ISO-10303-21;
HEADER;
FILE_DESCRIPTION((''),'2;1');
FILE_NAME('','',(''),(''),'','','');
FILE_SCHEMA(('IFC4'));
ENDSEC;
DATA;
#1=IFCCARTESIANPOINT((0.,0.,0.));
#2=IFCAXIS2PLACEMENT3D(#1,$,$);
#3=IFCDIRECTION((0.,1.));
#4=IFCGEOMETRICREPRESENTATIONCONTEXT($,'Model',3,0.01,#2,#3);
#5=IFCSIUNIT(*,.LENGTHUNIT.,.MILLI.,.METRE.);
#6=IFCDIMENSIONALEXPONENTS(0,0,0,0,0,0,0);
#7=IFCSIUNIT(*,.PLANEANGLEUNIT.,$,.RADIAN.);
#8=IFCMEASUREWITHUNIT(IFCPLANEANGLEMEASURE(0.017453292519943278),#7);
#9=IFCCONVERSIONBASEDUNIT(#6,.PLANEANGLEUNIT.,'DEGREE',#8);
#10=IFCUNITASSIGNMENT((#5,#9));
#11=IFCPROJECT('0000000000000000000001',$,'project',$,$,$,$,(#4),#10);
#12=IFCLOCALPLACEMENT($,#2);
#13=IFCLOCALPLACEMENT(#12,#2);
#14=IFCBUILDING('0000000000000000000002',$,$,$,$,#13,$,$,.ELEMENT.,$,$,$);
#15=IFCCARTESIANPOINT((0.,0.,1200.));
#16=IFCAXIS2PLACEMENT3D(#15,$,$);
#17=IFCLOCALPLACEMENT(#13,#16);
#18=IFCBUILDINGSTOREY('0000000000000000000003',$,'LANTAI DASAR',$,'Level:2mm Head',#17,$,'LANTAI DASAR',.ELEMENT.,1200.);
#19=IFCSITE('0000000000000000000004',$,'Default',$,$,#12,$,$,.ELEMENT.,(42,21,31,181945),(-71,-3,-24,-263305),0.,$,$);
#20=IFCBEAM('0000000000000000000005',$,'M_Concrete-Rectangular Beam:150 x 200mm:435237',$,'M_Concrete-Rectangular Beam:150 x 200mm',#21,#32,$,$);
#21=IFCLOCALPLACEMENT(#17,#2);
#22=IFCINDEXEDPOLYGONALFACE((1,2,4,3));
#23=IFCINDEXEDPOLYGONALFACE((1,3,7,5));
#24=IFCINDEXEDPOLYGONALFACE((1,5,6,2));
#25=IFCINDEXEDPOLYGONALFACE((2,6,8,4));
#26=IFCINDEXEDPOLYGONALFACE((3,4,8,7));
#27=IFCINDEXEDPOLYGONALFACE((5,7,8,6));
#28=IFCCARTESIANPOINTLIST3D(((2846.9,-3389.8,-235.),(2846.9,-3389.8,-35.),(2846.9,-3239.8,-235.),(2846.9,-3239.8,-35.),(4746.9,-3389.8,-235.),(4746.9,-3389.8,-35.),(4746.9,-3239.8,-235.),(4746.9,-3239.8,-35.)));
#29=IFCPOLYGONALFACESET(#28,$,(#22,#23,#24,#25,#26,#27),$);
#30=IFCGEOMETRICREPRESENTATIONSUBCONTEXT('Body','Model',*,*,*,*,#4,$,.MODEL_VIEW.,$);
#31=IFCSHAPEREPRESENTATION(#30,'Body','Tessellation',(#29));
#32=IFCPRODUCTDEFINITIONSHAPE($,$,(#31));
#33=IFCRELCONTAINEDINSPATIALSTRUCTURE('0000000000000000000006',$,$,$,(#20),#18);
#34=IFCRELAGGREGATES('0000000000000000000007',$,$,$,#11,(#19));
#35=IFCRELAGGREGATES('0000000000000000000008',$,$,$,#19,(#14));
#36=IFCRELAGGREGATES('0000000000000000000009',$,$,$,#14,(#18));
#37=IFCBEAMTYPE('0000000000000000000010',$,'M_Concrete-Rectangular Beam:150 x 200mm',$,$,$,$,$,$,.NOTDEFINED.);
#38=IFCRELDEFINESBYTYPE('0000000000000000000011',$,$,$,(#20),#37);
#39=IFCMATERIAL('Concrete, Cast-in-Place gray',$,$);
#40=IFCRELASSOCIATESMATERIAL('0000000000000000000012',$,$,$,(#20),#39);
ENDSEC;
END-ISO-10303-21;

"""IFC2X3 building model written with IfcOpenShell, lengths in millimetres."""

from ifc_helpers import new_model, entity, si_unit, converted_unit, direction, frame, frame_2d, origin, place, context, subcontext, project, spatial, rectangle, extrude, material, type_object, element, save


model = new_model("IFC2X3")

# Units and contexts
model_context = context("Model", 3, precision=0.01, world=origin(), true_north=direction((0.0, 1.0)))
body_context = subcontext(model_context, "Body", "Model", "MODEL_VIEW")
ifc_project = project(units=[si_unit("LENGTHUNIT", "METRE", prefix="MILLI"), converted_unit("PLANEANGLEUNIT", "DEGREE", entity("IfcPlaneAngleMeasure", 0.017453292519943278), si_unit("PLANEANGLEUNIT", "RADIAN"), dimensions=[0, 0, 0, 0, 0, 0, 0])], contexts=[model_context])

# Site, building, storey
site_placement = place(None, origin())
site = spatial("IfcSite", under=ifc_project, at=site_placement, Name="Default", CompositionType="ELEMENT", RefLatitude=(42, 21, 31, 181945), RefLongitude=(-71, -3, -24, -263305), RefElevation=0.0)
building_placement = place(site_placement, origin())
building = spatial("IfcBuilding", under=site, at=building_placement, CompositionType="ELEMENT")
storey_placement = place(building_placement, frame((0.0, 0.0, 1200.0)))
storey = spatial("IfcBuildingStorey", under=building, at=storey_placement, Name="LANTAI DASAR", ObjectType="Level:2mm Head", LongName="LANTAI DASAR", CompositionType="ELEMENT", Elevation=1200.0)

# Shared definitions
ifc_material = material(Name="Concrete, Cast-in-Place gray")

# Beam
beam_type = type_object("IfcBeamType", Name="M_Concrete-Rectangular Beam:150 x 200mm", PredefinedType="NOTDEFINED")
beam_1_placement = place(storey_placement, frame((2721.9, -3314.8, -35.0)))
element("IfcBeam", 1, at=beam_1_placement, inside=storey, type_object=beam_type, material=ifc_material, Name="M_Concrete-Rectangular Beam:150 x 200mm:435237", ObjectType="M_Concrete-Rectangular Beam:150 x 200mm", context=body_context, shape_type="SweptSolid", body=[
    extrude(rectangle(XDim=200.0, YDim=150.0, at=frame_2d((0.0, 0.0), x_axis=(1.0, 0.0))), frame((125.0, 0.0, -100.0), z_axis=(1.0, 0.0, 0.0), x_axis=(0.0, 0.0, -1.0)), (0.0, 0.0, 1.0), 1900.0),
])

save(model, "model.ifc")
